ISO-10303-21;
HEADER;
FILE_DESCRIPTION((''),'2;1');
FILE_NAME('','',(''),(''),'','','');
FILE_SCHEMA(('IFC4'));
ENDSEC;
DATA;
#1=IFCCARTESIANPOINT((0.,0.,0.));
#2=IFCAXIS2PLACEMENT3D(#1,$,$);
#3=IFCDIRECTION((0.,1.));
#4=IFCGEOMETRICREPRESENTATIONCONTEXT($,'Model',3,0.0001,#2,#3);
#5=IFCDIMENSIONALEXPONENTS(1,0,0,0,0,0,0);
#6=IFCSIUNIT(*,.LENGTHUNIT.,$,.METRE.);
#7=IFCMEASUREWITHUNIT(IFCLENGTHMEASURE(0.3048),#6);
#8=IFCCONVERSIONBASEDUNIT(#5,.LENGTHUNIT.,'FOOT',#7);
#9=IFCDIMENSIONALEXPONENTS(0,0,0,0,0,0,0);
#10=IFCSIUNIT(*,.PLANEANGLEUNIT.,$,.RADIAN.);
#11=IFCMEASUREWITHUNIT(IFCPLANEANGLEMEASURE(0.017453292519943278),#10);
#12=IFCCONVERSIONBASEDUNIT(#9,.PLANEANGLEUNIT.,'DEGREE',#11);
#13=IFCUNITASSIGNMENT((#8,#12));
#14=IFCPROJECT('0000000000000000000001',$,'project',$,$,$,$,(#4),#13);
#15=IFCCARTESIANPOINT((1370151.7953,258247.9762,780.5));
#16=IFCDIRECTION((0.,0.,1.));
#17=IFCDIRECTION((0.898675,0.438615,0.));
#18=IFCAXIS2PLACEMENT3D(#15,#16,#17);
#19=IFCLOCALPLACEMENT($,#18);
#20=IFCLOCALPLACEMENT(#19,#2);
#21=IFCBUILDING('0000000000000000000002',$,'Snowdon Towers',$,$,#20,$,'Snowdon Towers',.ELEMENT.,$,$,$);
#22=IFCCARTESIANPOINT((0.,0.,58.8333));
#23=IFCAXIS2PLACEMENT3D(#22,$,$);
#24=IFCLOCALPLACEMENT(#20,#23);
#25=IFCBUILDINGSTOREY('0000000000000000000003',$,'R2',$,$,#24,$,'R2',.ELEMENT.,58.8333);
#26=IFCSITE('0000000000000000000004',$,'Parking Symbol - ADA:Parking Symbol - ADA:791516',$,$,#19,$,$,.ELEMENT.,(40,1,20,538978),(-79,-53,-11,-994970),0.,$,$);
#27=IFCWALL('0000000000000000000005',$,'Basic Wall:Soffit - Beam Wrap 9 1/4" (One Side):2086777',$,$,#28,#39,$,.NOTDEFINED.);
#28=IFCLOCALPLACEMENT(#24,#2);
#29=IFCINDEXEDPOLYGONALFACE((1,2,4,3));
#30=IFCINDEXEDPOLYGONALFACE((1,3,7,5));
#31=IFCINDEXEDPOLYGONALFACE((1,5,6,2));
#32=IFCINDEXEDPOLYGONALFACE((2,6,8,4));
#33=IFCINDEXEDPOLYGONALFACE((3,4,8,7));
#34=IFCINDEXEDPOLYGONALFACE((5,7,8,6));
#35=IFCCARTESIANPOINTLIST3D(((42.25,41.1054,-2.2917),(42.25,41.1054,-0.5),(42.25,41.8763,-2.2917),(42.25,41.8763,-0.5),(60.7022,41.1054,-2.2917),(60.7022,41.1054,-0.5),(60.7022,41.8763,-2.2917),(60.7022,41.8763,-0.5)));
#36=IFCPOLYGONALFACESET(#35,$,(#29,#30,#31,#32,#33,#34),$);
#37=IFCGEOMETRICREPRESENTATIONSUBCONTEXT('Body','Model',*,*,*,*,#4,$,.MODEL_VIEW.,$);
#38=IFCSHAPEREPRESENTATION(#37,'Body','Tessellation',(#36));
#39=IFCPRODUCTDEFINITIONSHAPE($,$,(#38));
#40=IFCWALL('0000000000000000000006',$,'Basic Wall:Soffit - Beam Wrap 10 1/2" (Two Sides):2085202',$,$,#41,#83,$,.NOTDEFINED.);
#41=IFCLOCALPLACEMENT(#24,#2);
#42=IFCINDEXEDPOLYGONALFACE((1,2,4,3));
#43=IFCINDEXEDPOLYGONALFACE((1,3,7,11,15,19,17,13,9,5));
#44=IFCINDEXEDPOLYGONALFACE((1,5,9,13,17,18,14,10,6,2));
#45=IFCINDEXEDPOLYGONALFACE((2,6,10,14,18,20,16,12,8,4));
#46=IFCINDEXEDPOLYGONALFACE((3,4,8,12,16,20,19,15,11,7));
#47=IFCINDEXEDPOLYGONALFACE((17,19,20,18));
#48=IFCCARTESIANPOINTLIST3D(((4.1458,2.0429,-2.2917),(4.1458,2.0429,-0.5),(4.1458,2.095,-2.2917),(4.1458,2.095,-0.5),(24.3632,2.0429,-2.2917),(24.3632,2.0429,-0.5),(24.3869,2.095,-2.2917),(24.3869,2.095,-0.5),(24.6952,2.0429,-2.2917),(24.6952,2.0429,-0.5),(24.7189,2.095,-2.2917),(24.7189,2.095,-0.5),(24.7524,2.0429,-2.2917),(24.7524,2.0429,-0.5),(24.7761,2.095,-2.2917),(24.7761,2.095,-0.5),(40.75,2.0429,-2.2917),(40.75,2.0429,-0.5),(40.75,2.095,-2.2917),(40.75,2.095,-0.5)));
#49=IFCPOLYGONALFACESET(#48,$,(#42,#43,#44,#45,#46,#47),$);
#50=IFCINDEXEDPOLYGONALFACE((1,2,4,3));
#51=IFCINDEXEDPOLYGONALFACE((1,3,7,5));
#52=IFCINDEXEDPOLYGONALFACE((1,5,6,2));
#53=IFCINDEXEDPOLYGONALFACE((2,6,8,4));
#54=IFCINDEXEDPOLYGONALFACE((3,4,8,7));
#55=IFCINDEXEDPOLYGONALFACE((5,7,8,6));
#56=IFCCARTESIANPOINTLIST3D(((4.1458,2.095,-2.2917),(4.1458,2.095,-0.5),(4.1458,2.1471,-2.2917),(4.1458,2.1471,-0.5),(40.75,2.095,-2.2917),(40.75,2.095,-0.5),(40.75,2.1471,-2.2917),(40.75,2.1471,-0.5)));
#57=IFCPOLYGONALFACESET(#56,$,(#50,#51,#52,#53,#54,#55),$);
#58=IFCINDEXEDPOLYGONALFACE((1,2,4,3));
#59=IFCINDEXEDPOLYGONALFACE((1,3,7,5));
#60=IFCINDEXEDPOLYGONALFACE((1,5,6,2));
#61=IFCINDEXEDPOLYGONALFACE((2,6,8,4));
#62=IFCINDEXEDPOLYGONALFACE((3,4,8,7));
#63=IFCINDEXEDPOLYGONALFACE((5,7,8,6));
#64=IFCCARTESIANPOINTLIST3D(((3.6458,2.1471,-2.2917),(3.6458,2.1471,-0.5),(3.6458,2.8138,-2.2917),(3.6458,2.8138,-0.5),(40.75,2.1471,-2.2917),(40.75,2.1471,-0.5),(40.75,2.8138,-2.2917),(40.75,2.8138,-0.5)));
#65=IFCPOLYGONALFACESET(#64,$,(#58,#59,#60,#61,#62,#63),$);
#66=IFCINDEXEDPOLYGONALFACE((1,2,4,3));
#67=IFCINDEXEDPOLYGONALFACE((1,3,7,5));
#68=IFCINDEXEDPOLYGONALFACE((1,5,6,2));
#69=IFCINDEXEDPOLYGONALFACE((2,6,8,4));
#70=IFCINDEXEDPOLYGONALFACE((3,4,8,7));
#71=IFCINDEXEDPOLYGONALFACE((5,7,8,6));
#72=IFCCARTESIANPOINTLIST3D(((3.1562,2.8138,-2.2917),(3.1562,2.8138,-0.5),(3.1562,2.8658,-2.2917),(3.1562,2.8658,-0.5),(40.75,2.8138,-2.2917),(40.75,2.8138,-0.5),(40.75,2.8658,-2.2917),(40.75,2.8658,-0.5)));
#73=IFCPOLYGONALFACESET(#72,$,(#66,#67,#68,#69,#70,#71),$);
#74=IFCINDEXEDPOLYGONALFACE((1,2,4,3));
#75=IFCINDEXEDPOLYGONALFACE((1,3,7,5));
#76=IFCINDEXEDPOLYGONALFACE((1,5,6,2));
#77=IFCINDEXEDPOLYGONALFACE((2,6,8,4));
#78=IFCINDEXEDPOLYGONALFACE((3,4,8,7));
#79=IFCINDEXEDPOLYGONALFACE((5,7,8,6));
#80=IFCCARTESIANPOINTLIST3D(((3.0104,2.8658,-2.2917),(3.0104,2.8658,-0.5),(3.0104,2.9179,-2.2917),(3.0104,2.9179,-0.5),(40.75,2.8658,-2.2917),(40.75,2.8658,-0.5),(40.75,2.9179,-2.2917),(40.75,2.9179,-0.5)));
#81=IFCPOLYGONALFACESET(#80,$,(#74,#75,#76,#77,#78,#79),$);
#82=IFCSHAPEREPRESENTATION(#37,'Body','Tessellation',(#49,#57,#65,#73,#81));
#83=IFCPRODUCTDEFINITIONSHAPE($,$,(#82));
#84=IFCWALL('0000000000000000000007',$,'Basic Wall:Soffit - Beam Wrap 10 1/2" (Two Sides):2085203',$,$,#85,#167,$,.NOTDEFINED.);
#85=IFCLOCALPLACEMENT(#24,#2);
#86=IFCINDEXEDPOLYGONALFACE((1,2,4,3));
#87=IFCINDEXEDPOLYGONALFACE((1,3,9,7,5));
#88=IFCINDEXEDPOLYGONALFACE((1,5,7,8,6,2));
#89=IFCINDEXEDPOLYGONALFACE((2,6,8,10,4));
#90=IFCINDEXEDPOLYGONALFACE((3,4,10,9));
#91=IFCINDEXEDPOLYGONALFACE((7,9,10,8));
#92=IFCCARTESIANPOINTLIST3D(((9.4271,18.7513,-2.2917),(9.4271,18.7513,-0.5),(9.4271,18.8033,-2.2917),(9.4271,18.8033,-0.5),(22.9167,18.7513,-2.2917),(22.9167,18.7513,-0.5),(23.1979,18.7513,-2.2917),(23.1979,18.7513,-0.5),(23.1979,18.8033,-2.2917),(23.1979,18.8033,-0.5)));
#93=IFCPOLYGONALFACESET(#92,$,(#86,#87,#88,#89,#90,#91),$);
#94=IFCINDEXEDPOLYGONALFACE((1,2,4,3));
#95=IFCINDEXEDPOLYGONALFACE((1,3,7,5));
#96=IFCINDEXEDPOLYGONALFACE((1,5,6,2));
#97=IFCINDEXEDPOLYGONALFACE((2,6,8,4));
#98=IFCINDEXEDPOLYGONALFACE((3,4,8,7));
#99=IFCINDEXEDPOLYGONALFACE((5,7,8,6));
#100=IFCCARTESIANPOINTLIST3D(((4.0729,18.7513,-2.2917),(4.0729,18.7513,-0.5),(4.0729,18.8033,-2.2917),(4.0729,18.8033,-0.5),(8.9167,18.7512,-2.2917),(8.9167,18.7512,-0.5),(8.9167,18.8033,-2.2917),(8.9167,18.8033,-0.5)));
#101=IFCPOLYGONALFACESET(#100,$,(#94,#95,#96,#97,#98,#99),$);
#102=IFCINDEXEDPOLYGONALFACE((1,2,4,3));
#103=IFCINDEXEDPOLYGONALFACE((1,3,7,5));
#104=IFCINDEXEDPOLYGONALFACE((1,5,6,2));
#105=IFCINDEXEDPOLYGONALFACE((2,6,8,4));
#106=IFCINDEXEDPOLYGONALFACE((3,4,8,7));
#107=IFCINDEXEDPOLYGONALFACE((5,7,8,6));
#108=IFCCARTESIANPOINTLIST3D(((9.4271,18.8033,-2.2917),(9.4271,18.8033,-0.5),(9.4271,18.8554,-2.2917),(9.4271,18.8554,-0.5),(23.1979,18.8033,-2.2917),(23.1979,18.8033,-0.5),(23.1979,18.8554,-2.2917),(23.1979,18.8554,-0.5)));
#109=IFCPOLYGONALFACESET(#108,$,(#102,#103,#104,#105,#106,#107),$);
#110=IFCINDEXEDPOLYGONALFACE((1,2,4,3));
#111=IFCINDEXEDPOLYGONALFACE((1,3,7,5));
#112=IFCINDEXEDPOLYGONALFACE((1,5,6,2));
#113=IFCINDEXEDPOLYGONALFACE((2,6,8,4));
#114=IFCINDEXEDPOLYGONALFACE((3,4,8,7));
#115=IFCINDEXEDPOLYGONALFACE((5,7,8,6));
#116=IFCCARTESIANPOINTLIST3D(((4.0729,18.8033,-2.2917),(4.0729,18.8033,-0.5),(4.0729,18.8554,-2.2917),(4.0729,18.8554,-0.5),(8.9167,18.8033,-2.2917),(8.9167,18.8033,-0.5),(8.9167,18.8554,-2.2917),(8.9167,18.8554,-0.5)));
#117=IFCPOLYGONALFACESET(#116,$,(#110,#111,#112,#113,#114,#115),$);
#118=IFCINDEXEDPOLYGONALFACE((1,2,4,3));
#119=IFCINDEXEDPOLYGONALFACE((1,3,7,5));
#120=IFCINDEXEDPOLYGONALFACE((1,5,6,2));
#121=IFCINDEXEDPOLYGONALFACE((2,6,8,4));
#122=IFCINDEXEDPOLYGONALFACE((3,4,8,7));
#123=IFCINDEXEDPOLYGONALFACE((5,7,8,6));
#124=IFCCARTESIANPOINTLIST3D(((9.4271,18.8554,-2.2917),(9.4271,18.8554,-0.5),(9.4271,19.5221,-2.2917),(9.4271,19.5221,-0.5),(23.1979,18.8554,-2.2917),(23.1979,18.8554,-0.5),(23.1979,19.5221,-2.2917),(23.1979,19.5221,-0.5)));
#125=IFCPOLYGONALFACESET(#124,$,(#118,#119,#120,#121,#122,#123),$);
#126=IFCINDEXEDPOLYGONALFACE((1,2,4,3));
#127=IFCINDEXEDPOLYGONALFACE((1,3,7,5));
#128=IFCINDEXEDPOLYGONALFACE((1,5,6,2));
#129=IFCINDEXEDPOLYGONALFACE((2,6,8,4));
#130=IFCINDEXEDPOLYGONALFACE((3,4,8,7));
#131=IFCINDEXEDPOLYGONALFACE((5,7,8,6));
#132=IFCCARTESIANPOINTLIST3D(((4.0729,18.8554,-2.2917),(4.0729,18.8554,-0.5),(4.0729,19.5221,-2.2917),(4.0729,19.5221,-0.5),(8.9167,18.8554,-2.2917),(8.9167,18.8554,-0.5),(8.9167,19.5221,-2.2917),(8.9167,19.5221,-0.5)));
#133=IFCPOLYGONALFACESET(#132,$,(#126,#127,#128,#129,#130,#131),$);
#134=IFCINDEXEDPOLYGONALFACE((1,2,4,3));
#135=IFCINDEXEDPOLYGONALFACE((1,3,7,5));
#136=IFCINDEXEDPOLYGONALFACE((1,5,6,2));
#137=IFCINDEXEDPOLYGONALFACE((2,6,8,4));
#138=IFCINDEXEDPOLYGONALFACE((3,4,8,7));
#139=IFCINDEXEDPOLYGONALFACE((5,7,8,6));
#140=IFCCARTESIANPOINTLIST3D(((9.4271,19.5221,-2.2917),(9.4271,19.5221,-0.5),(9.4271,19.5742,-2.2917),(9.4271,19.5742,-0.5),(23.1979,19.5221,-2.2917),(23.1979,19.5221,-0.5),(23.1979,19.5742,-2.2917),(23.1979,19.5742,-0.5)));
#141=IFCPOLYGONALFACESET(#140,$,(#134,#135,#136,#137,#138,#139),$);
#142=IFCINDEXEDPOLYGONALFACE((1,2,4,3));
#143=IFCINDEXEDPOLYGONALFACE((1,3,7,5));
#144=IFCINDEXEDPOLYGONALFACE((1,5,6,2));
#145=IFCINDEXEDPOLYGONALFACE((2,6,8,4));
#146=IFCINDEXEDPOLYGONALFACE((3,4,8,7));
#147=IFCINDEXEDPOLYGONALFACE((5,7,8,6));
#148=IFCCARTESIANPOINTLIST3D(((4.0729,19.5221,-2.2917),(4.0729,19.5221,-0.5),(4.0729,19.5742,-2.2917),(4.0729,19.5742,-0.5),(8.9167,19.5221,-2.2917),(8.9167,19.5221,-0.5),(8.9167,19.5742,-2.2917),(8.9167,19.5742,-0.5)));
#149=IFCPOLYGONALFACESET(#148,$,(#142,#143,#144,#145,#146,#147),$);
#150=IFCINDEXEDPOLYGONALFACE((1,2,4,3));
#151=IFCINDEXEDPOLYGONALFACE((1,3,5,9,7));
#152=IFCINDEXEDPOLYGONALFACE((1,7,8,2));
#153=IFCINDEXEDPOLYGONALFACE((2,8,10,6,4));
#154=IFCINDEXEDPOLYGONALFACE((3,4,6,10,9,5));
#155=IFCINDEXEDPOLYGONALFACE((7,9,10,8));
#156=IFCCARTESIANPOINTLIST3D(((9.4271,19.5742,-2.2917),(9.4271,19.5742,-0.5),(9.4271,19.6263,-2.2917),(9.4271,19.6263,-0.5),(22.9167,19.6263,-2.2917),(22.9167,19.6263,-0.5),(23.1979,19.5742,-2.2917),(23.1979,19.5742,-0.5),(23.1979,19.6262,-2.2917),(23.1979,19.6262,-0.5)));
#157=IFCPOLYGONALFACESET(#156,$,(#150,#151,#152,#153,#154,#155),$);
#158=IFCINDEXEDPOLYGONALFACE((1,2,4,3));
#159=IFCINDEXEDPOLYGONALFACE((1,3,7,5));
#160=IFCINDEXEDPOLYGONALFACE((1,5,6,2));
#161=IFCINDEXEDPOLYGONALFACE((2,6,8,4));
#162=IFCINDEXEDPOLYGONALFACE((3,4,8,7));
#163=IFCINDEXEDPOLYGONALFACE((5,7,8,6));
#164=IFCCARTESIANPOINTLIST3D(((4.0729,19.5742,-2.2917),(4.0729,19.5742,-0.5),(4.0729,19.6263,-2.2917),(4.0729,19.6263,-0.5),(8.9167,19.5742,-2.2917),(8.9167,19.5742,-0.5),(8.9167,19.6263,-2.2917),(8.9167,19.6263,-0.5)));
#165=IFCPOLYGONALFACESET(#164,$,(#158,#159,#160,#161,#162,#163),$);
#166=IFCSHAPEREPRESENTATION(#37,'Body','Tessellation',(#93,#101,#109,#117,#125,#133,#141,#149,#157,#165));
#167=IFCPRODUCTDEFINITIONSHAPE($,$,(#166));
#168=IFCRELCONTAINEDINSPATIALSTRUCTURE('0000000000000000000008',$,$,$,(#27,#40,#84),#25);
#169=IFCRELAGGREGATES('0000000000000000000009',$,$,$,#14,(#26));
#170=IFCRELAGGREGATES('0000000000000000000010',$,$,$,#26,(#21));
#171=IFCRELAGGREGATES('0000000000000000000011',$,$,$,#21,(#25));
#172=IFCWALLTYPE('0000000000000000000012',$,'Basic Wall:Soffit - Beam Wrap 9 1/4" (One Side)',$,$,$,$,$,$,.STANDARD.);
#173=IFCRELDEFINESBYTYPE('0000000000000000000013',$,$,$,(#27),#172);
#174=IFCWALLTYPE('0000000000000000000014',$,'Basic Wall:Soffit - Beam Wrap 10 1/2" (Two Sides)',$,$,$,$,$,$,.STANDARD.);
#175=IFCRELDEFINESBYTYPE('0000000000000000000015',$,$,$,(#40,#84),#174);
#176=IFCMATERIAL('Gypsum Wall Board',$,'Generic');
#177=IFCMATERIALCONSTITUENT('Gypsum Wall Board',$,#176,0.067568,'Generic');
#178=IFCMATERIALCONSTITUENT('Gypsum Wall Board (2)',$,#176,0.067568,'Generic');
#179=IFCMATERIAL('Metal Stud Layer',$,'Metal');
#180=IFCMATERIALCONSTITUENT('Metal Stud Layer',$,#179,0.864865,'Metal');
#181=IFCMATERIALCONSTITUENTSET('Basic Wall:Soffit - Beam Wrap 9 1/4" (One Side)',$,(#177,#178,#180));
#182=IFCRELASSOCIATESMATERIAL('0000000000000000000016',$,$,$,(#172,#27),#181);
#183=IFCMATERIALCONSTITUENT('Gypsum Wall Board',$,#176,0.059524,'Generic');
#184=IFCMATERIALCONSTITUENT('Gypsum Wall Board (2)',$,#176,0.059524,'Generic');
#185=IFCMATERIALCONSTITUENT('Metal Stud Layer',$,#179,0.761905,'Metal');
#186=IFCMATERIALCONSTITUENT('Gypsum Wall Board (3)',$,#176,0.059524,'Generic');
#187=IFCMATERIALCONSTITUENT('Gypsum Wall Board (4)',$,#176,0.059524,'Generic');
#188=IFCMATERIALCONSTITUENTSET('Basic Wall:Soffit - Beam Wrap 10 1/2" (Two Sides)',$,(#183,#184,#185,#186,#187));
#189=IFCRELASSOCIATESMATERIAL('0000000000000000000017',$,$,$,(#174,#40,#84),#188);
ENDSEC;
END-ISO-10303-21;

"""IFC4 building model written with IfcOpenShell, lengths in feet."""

from ifc_helpers import new_model, entity, si_unit, converted_unit, direction, frame, origin, place, context, subcontext, project, spatial, indexed_curve, outline, extrude, material, constituent, constituent_set, type_object, element, save


model = new_model("IFC4")

# Units and contexts
model_context = context("Model", 3, precision=0.0001, world=origin(), true_north=direction((0.0, 1.0)))
body_context = subcontext(model_context, "Body", "Model", "MODEL_VIEW")
ifc_project = project(units=[converted_unit("LENGTHUNIT", "FOOT", entity("IfcLengthMeasure", 0.3048), si_unit("LENGTHUNIT", "METRE"), dimensions=[1, 0, 0, 0, 0, 0, 0]), converted_unit("PLANEANGLEUNIT", "DEGREE", entity("IfcPlaneAngleMeasure", 0.017453292519943278), si_unit("PLANEANGLEUNIT", "RADIAN"), dimensions=[0, 0, 0, 0, 0, 0, 0])], contexts=[model_context])

# Site, building, storey
site_placement = place(None, frame((1370151.7953, 258247.9762, 780.5), z_axis=(0.0, 0.0, 1.0), x_axis=(0.898675, 0.438615, 0.0)))
site = spatial("IfcSite", under=ifc_project, at=site_placement, Name="Parking Symbol - ADA:Parking Symbol - ADA:791516", CompositionType="ELEMENT", RefLatitude=(40, 1, 20, 538978), RefLongitude=(-79, -53, -11, -994970), RefElevation=0.0)
building_placement = place(site_placement, origin())
building = spatial("IfcBuilding", under=site, at=building_placement, Name="Snowdon Towers", LongName="Snowdon Towers", CompositionType="ELEMENT")
storey_placement = place(building_placement, frame((0.0, 0.0, 58.8333)))
storey = spatial("IfcBuildingStorey", under=building, at=storey_placement, Name="R2", LongName="R2", CompositionType="ELEMENT", Elevation=58.8333)

# Shared definitions
ifc_material_1 = material(Name="Gypsum Wall Board", Category="Generic")
ifc_material_2 = material(Name="Metal Stud Layer", Category="Metal")

# Walls
ifc_constituent_1 = constituent(ifc_material_1, Name="Gypsum Wall Board", Category="Generic", fraction=0.067568)
ifc_constituent_2 = constituent(ifc_material_1, Name="Gypsum Wall Board (2)", Category="Generic", fraction=0.067568)
ifc_constituent_3 = constituent(ifc_material_2, Name="Metal Stud Layer", Category="Metal", fraction=0.864865)
ifc_constituent_set_1 = constituent_set(constituents=[ifc_constituent_1, ifc_constituent_2, ifc_constituent_3], Name="Basic Wall:Soffit - Beam Wrap 9 1/4\" (One Side)")
wall_type_1 = type_object("IfcWallType", Name="Basic Wall:Soffit - Beam Wrap 9 1/4\" (One Side)", PredefinedType="STANDARD", material=ifc_constituent_set_1)
wall_1_placement = place(storey_placement, frame((42.25, 41.4908, -2.2917)))
element("IfcWall", 1, at=wall_1_placement, inside=storey, type_object=wall_type_1, material=ifc_constituent_set_1, Name="Basic Wall:Soffit - Beam Wrap 9 1/4\" (One Side):2086777", PredefinedType="NOTDEFINED", context=body_context, shape_type="SweptSolid", body=[
    extrude(outline(indexed_curve([(18.4522, 0.3854), (0.0, 0.3854), (0.0, -0.3854), (18.4522, -0.3854), (18.4522, 0.3854)], self_intersect=False)), origin(), (0.0, 0.0, 1.0), 1.7917),
])
ifc_constituent_4 = constituent(ifc_material_1, Name="Gypsum Wall Board", Category="Generic", fraction=0.059524)
ifc_constituent_5 = constituent(ifc_material_1, Name="Gypsum Wall Board (2)", Category="Generic", fraction=0.059524)
ifc_constituent_6 = constituent(ifc_material_2, Name="Metal Stud Layer", Category="Metal", fraction=0.761905)
ifc_constituent_7 = constituent(ifc_material_1, Name="Gypsum Wall Board (3)", Category="Generic", fraction=0.059524)
ifc_constituent_8 = constituent(ifc_material_1, Name="Gypsum Wall Board (4)", Category="Generic", fraction=0.059524)
ifc_constituent_set_2 = constituent_set(constituents=[ifc_constituent_4, ifc_constituent_5, ifc_constituent_6, ifc_constituent_7, ifc_constituent_8], Name="Basic Wall:Soffit - Beam Wrap 10 1/2\" (Two Sides)")
wall_type_2 = type_object("IfcWallType", Name="Basic Wall:Soffit - Beam Wrap 10 1/2\" (Two Sides)", PredefinedType="STANDARD", material=ifc_constituent_set_2)
wall_2_placement = place(storey_placement, frame((4.1458, 2.4804, -2.2917)))
element("IfcWall", 2, at=wall_2_placement, inside=storey, type_object=wall_type_2, material=ifc_constituent_set_2, Name="Basic Wall:Soffit - Beam Wrap 10 1/2\" (Two Sides):2085202", PredefinedType="NOTDEFINED", context=body_context, shape_type="SweptSolid", body=[
    extrude(outline(indexed_curve([(0.6148, -0.026), (0.9467, -0.026), (1.004, -0.026), (17.0016, -0.026), (17.0016, 0.026), (1.0277, 0.026), (0.9705, 0.026), (0.6385, 0.026), (-19.6026, 0.026), (-19.6026, -0.026), (0.6148, -0.026)], self_intersect=False)), frame((19.6026, -0.4115, 0.0)), (0.0, 0.0, 1.0), 1.7917),
    extrude(outline(indexed_curve([(-18.3021, -0.026), (18.3021, -0.026), (18.3021, 0.026), (-18.3021, 0.026), (-18.3021, -0.026)], self_intersect=False)), frame((18.3021, -0.3594, 0.0)), (0.0, 0.0, 1.0), 1.7917),
    extrude(outline(indexed_curve([(-18.5521, -0.3333), (18.5521, -0.3333), (18.5521, 0.3333), (-18.5521, 0.3333), (-18.5521, -0.3333)], self_intersect=False)), frame((18.0521, 0.0, 0.0)), (0.0, 0.0, 1.0), 1.7917),
    extrude(outline(indexed_curve([(-18.7969, -0.026), (18.7969, -0.026), (18.7969, 0.026), (-18.7969, 0.026), (-18.7969, -0.026)], self_intersect=False)), frame((17.8073, 0.3594, 0.0)), (0.0, 0.0, 1.0), 1.7917),
    extrude(outline(indexed_curve([(-0.026, -18.8698), (0.026, -18.8698), (0.026, 18.8698), (-0.026, 18.8698), (-0.026, -18.8698)], self_intersect=False)), frame((17.7344, 0.4115, 0.0), z_axis=(0.0, 0.0, 1.0), x_axis=(0.0, -1.0, 0.0)), (0.0, 0.0, 1.0), 1.7917),
])
wall_3_placement = place(storey_placement, frame((4.0729, 19.1887, -2.2917)))
element("IfcWall", 3, at=wall_3_placement, inside=storey, type_object=wall_type_2, material=ifc_constituent_set_2, Name="Basic Wall:Soffit - Beam Wrap 10 1/2\" (Two Sides):2085203", PredefinedType="NOTDEFINED", context=body_context, shape_type="SweptSolid", body=[
    extrude(outline(indexed_curve([(5.2833, -0.0208), (5.5646, -0.0208), (5.5646, 0.0313), (-8.2063, 0.0312), (-8.2063, -0.0208), (5.2833, -0.0208)], self_intersect=False)), frame((13.5604, -0.4167, 0.0)), (0.0, 0.0, 1.0), 1.7917),
    extrude(outline(indexed_curve([(-0.026, -2.4219), (0.026, -2.4219), (0.026, 2.4219), (-0.026, 2.4219), (-0.026, -2.4219)], self_intersect=False)), frame((2.4219, -0.4115, 0.0), z_axis=(0.0, 0.0, 1.0), x_axis=(0.0, 1.0, 0.0)), (0.0, 0.0, 1.0), 1.7917),
    extrude(outline(indexed_curve([(-6.8854, -0.026), (6.8854, -0.026), (6.8854, 0.026), (-6.8854, 0.026), (-6.8854, -0.026)], self_intersect=False)), frame((12.2396, -0.3594, 0.0)), (0.0, 0.0, 1.0), 1.7917),
    extrude(outline(indexed_curve([(-2.4219, -0.026), (2.4219, -0.026), (2.4219, 0.026), (-2.4219, 0.026), (-2.4219, -0.026)], self_intersect=False)), frame((2.4219, -0.3594, 0.0)), (0.0, 0.0, 1.0), 1.7917),
    extrude(outline(indexed_curve([(-6.8854, -0.3333), (6.8854, -0.3333), (6.8854, 0.3333), (-6.8854, 0.3333), (-6.8854, -0.3333)], self_intersect=False)), frame((12.2396, 0.0, 0.0)), (0.0, 0.0, 1.0), 1.7917),
    extrude(outline(indexed_curve([(-2.4219, -0.3333), (2.4219, -0.3333), (2.4219, 0.3333), (-2.4219, 0.3333), (-2.4219, -0.3333)], self_intersect=False)), frame((2.4219, 0.0, 0.0)), (0.0, 0.0, 1.0), 1.7917),
    extrude(outline(indexed_curve([(-6.8854, -0.026), (6.8854, -0.026), (6.8854, 0.026), (-6.8854, 0.026), (-6.8854, -0.026)], self_intersect=False)), frame((12.2396, 0.3594, 0.0)), (0.0, 0.0, 1.0), 1.7917),
    extrude(outline(indexed_curve([(-2.4219, -0.026), (2.4219, -0.026), (2.4219, 0.026), (-2.4219, 0.026), (-2.4219, -0.026)], self_intersect=False)), frame((2.4219, 0.3594, 0.0)), (0.0, 0.0, 1.0), 1.7917),
    extrude(outline(indexed_curve([(-5.2833, -0.0208), (8.2063, -0.0208), (8.2063, 0.0312), (-5.5646, 0.0313), (-5.5646, -0.0208), (-5.2833, -0.0208)], self_intersect=False)), frame((13.5604, 0.4167, 0.0), z_axis=(0.0, 0.0, 1.0), x_axis=(-1.0, 0.0, 0.0)), (0.0, 0.0, 1.0), 1.7917),
    extrude(outline(indexed_curve([(-0.026, -2.4219), (0.026, -2.4219), (0.026, 2.4219), (-0.026, 2.4219), (-0.026, -2.4219)], self_intersect=False)), frame((2.4219, 0.4115, 0.0), z_axis=(0.0, 0.0, 1.0), x_axis=(0.0, -1.0, 0.0)), (0.0, 0.0, 1.0), 1.7917),
])

save(model, "model.ifc")
